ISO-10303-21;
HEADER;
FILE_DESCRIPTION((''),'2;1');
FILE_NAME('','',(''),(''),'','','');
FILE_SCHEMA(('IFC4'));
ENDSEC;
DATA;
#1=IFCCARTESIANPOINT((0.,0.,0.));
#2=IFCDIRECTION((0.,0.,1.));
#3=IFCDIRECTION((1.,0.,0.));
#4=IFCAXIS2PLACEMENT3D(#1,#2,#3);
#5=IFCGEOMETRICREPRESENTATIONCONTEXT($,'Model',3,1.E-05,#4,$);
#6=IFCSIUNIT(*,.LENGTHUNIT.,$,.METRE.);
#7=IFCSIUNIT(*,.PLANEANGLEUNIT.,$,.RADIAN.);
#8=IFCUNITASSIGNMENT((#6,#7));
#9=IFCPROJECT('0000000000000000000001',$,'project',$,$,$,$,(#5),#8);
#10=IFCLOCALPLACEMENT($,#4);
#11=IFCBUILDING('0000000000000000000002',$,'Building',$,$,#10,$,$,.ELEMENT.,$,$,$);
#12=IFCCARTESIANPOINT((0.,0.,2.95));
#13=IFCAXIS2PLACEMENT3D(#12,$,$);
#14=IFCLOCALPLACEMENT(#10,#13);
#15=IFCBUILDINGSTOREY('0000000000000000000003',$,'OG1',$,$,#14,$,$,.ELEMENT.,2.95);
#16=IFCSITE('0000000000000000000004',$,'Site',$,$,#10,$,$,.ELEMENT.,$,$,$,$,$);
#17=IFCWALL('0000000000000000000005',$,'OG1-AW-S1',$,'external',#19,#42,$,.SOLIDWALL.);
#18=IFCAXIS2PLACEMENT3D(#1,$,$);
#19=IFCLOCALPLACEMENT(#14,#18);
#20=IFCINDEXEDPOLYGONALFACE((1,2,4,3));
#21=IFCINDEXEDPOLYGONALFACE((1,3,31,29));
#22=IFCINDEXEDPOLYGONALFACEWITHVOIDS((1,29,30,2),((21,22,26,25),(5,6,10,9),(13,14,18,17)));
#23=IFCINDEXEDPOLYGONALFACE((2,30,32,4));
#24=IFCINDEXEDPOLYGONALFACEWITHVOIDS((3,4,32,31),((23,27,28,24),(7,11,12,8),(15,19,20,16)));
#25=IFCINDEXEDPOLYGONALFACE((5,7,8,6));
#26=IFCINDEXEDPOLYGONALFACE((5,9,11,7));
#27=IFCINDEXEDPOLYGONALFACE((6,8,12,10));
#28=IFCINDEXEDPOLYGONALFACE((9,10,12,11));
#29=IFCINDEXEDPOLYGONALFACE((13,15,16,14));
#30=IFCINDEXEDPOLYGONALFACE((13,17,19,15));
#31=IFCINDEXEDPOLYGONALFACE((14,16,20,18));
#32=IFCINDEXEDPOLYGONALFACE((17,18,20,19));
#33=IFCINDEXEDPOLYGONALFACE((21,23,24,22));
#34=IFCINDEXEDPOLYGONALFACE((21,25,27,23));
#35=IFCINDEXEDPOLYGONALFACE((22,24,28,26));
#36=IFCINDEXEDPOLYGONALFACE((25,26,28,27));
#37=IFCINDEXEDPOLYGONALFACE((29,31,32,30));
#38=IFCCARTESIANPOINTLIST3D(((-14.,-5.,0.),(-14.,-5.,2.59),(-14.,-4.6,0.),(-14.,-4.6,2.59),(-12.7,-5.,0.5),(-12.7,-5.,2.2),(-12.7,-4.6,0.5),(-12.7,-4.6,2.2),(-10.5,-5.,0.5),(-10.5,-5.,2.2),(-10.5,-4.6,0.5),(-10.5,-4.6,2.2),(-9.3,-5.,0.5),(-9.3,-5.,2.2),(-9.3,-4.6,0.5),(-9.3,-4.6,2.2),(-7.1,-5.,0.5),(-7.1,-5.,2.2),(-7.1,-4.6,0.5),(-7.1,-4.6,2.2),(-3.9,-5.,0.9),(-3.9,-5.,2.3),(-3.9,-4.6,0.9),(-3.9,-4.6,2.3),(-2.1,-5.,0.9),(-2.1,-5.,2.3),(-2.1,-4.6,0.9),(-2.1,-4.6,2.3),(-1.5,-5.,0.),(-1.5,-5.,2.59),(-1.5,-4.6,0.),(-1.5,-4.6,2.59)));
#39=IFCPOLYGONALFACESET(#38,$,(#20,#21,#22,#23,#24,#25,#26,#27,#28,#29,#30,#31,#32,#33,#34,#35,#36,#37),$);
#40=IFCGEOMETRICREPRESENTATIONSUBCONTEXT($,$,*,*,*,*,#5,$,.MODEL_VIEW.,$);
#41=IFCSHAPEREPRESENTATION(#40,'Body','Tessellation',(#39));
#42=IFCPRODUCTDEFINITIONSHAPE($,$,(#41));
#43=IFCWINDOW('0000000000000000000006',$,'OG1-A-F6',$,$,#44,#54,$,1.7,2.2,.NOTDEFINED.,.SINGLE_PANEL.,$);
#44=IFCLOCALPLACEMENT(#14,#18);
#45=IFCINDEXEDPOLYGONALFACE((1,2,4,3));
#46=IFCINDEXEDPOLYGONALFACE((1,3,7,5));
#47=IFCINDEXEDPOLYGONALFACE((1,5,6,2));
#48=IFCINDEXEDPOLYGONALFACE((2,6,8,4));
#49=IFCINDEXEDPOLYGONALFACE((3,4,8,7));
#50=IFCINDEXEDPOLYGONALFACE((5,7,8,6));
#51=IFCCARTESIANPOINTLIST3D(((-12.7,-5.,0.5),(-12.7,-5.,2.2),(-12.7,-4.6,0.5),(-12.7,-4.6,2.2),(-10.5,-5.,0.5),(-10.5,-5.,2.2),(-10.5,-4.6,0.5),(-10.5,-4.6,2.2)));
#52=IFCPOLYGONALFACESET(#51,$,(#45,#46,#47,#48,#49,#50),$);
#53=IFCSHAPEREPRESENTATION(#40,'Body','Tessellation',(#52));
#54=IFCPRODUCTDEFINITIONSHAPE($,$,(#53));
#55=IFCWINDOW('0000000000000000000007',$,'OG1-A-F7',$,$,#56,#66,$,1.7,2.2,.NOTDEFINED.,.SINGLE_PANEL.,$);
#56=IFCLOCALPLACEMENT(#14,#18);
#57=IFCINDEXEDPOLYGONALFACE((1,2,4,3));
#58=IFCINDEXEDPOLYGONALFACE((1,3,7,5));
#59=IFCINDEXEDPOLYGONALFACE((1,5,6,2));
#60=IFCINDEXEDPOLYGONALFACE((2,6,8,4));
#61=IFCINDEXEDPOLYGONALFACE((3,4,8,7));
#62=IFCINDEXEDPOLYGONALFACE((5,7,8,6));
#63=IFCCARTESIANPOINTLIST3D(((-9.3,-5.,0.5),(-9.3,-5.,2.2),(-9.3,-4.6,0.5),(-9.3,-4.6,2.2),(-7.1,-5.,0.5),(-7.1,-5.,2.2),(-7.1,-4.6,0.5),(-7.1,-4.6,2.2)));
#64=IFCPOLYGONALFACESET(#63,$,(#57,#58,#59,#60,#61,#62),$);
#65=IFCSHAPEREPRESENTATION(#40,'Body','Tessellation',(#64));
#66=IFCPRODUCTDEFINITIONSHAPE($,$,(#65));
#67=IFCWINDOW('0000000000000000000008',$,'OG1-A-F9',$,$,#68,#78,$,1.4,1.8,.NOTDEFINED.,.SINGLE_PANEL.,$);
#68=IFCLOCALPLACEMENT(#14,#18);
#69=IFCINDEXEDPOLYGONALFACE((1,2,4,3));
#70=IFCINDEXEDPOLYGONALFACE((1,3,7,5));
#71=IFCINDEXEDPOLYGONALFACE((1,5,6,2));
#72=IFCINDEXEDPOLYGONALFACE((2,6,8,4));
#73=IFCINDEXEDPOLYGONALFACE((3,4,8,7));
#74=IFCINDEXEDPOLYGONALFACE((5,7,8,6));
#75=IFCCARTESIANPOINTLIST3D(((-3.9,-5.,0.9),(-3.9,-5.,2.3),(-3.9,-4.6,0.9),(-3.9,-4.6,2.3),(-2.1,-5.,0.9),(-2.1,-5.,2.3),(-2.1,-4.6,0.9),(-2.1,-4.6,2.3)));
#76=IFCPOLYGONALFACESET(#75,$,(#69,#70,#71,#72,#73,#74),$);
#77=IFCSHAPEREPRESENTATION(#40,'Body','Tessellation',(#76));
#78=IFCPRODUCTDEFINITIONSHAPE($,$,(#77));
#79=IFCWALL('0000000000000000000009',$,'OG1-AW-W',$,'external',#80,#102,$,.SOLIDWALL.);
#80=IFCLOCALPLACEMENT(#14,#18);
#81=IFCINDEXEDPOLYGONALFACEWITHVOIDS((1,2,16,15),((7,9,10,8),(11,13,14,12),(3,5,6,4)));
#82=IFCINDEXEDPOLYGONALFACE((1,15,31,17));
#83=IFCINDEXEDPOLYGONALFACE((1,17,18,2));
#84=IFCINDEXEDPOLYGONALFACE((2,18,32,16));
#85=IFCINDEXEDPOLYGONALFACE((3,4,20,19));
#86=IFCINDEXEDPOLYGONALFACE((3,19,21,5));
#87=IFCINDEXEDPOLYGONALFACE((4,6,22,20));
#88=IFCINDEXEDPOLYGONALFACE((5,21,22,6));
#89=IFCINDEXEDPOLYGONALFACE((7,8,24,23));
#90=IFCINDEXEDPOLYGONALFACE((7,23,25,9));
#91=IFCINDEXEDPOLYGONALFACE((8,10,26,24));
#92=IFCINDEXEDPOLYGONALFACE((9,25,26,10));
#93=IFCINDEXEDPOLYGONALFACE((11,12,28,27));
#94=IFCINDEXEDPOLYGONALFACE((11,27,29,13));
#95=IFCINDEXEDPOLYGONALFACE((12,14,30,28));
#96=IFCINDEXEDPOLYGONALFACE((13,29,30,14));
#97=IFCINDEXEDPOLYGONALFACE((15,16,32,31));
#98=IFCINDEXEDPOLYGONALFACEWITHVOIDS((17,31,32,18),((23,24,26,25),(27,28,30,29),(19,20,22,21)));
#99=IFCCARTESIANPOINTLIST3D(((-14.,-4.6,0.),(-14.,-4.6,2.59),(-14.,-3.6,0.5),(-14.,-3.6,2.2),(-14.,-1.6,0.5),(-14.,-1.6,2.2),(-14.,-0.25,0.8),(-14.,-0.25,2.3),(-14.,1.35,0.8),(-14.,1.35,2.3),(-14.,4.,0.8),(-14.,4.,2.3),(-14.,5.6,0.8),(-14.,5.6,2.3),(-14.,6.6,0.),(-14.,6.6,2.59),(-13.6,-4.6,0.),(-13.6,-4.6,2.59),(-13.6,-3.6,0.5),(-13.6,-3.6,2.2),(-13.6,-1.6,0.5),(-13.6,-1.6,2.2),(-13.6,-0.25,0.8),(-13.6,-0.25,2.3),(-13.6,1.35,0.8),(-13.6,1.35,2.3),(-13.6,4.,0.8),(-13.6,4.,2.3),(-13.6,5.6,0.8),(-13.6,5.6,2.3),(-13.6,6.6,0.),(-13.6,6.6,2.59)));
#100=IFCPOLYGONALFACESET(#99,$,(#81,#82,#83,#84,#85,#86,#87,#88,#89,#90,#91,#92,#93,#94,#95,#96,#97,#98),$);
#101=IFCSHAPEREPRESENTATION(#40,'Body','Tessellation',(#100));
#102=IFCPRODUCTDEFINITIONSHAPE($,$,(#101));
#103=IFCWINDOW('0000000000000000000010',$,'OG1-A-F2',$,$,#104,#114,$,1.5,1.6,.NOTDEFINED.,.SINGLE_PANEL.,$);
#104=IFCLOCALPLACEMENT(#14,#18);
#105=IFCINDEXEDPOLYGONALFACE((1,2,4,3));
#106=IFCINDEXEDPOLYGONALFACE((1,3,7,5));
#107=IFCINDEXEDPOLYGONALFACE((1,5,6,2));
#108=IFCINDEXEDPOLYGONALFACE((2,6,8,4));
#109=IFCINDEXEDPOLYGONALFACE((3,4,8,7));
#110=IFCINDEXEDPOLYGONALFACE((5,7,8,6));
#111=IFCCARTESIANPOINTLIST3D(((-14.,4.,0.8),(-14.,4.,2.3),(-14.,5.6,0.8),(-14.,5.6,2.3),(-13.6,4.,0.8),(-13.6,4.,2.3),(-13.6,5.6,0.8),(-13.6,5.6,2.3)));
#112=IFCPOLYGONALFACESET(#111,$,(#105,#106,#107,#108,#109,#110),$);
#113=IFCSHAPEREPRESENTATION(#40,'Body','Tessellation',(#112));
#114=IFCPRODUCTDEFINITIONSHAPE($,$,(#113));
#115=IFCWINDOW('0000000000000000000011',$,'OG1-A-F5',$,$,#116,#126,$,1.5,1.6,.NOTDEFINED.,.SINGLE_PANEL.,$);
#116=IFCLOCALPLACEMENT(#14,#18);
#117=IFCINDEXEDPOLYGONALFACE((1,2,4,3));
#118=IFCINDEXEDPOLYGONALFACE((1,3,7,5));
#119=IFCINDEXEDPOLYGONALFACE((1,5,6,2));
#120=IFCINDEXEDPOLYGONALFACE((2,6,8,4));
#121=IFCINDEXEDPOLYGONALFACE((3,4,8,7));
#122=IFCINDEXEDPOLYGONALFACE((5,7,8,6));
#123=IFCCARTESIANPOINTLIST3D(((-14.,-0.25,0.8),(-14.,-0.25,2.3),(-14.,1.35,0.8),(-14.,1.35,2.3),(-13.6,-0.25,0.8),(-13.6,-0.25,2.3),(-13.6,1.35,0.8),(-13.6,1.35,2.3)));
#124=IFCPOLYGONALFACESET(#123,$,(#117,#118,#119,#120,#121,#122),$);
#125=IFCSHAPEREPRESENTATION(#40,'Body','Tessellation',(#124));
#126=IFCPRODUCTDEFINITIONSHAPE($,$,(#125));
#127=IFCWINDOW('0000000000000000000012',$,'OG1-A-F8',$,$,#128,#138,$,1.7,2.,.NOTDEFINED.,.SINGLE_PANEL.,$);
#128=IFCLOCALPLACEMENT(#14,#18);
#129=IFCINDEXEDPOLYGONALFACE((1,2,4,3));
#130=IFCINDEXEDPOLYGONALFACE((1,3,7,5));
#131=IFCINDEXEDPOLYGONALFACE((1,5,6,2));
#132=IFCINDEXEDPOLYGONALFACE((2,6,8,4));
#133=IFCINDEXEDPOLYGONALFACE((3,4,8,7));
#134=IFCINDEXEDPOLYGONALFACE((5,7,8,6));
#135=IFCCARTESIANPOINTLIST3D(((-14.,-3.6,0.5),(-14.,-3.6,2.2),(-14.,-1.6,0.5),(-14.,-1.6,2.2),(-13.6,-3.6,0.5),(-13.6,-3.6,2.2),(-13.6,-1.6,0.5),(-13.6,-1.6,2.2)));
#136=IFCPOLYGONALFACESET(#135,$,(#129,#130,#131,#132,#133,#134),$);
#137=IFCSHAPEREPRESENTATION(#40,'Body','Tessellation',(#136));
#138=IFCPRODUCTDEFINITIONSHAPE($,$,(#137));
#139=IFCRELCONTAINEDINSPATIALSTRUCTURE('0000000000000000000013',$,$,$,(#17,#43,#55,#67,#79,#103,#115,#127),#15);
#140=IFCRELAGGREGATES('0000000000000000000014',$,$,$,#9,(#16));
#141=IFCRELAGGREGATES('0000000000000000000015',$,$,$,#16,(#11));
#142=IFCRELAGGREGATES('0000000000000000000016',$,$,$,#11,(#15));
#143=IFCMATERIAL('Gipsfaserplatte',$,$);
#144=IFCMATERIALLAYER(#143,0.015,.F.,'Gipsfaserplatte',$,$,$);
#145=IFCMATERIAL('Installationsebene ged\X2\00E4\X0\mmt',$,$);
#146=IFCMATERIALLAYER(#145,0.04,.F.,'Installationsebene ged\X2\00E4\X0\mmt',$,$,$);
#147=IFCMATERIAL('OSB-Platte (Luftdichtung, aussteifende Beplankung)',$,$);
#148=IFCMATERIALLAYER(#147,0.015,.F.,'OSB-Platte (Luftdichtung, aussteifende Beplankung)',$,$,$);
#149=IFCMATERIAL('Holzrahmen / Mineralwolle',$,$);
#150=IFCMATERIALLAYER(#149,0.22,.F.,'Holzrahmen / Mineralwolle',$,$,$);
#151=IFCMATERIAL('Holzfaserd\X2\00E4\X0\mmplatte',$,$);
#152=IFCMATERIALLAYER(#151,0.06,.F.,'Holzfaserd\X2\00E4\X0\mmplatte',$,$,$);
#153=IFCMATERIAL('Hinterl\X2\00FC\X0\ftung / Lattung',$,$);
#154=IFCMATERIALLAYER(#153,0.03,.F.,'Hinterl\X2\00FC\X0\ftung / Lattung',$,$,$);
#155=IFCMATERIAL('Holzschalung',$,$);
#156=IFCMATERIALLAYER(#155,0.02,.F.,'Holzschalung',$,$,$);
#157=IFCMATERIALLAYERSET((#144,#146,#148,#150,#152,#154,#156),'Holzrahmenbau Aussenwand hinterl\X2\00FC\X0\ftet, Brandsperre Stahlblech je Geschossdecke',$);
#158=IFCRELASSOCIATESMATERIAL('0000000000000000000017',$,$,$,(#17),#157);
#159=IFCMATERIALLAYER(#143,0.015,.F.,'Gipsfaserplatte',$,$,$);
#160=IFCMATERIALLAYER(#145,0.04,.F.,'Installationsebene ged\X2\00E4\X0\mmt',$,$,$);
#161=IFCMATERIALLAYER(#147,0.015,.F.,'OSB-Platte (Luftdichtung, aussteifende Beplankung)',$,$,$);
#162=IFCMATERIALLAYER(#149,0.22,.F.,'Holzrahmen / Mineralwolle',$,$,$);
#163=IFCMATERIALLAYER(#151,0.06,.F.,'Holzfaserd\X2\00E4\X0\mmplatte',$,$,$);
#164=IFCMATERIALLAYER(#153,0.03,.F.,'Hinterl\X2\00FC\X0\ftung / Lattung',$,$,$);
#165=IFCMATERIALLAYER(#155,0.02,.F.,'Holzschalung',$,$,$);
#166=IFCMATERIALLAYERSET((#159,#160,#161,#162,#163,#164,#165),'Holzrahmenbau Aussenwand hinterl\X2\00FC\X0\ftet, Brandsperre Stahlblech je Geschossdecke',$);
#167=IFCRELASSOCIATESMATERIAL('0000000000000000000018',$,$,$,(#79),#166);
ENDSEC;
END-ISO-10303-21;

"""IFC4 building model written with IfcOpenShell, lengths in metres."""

from ifc_helpers import new_model, si_unit, frame, frame_2d, origin, origin_with_axes, place, context, subcontext, project, spatial, rectangle, extrude, material, layer, layer_set, element, fill, save


model = new_model("IFC4")

# Units and contexts
model_context = context("Model", 3, precision=1e-05, world=origin_with_axes())
sub_context = subcontext(model_context, None, None, "MODEL_VIEW")
ifc_project = project(units=[si_unit("LENGTHUNIT", "METRE"), si_unit("PLANEANGLEUNIT", "RADIAN")], contexts=[model_context])

# Site, building, storey
placement = place(None, origin_with_axes())
site = spatial("IfcSite", under=ifc_project, at=placement, Name="Site", CompositionType="ELEMENT")
building = spatial("IfcBuilding", under=site, at=placement, Name="Building", CompositionType="ELEMENT")
storey_placement = place(placement, frame((0.0, 0.0, 2.95)))
storey = spatial("IfcBuildingStorey", under=building, at=storey_placement, Name="OG1", CompositionType="ELEMENT", Elevation=2.95)

# Walls, openings, windows
ifc_material_1 = material(Name="Gipsfaserplatte")
ifc_layer_1 = layer(ifc_material_1, 0.015, ventilated=False, Name="Gipsfaserplatte")
ifc_material_2 = material(Name="Installationsebene gedämmt")
ifc_layer_2 = layer(ifc_material_2, 0.04, ventilated=False, Name="Installationsebene gedämmt")
ifc_material_3 = material(Name="OSB-Platte (Luftdichtung, aussteifende Beplankung)")
ifc_layer_3 = layer(ifc_material_3, 0.015, ventilated=False, Name="OSB-Platte (Luftdichtung, aussteifende Beplankung)")
ifc_material_4 = material(Name="Holzrahmen / Mineralwolle")
ifc_layer_4 = layer(ifc_material_4, 0.22, ventilated=False, Name="Holzrahmen / Mineralwolle")
ifc_material_5 = material(Name="Holzfaserdämmplatte")
ifc_layer_5 = layer(ifc_material_5, 0.06, ventilated=False, Name="Holzfaserdämmplatte")
ifc_material_6 = material(Name="Hinterlüftung / Lattung")
ifc_layer_6 = layer(ifc_material_6, 0.03, ventilated=False, Name="Hinterlüftung / Lattung")
ifc_material_7 = material(Name="Holzschalung")
ifc_layer_7 = layer(ifc_material_7, 0.02, ventilated=False, Name="Holzschalung")
ifc_layer_set_1 = layer_set([ifc_layer_1, ifc_layer_2, ifc_layer_3, ifc_layer_4, ifc_layer_5, ifc_layer_6, ifc_layer_7], Name="Holzrahmenbau Aussenwand hinterlüftet, Brandsperre Stahlblech je Geschossdecke")
wall_1_placement = place(storey_placement, frame((-14.0, -4.8, 0.0), z_axis=(0.0, 0.0, 1.0), x_axis=(1.0, 0.0, 0.0)))
wall_1 = element("IfcWall", 1, at=wall_1_placement, inside=storey, material=ifc_layer_set_1, Name="OG1-AW-S1", ObjectType="external", PredefinedType="SOLIDWALL", context=sub_context, shape_type="SweptSolid", body=[
    extrude(rectangle(XDim=12.5, YDim=0.4, at=frame_2d((6.25, 0.0))), origin(), (0.0, 0.0, 1.0), 2.59),
])
opening_1_placement = place(wall_1_placement, frame((2.4, 0.25, 0.5), z_axis=(0.0, -1.0, 0.0), x_axis=(1.0, 0.0, 0.0)))
opening_1 = element("IfcOpeningElement", 2, at=opening_1_placement, cuts=wall_1, PredefinedType="OPENING", context=sub_context, shape_type="SweptSolid", body=[
    extrude(rectangle(XDim=2.2, YDim=1.7, at=frame_2d((0.0, 0.85))), origin(), (0.0, 0.0, 1.0), 0.5),
])
opening_2_placement = place(wall_1_placement, frame((5.8, 0.25, 0.5), z_axis=(0.0, -1.0, 0.0), x_axis=(1.0, 0.0, 0.0)))
opening_2 = element("IfcOpeningElement", 3, at=opening_2_placement, cuts=wall_1, PredefinedType="OPENING", context=sub_context, shape_type="SweptSolid", body=[
    extrude(rectangle(XDim=2.2, YDim=1.7, at=frame_2d((0.0, 0.85))), origin(), (0.0, 0.0, 1.0), 0.5),
])
opening_3_placement = place(wall_1_placement, frame((11.0, 0.25, 0.9), z_axis=(0.0, -1.0, 0.0), x_axis=(1.0, 0.0, 0.0)))
opening_3 = element("IfcOpeningElement", 4, at=opening_3_placement, cuts=wall_1, PredefinedType="OPENING", context=sub_context, shape_type="SweptSolid", body=[
    extrude(rectangle(XDim=1.8, YDim=1.4, at=frame_2d((0.0, 0.7))), origin(), (0.0, 0.0, 1.0), 0.5),
])
window_1_placement = place(wall_1_placement, frame((2.4, 0.2, 0.5), z_axis=(0.0, -1.0, 0.0), x_axis=(1.0, 0.0, 0.0)))
window_1 = element("IfcWindow", 5, at=window_1_placement, inside=storey, Name="OG1-A-F6", OverallHeight=1.7, OverallWidth=2.2, PartitioningType="SINGLE_PANEL", PredefinedType="NOTDEFINED", context=sub_context, shape_type="SweptSolid", body=[
    extrude(rectangle(XDim=2.2, YDim=1.7, at=frame_2d((0.0, 0.85))), origin(), (0.0, 0.0, 1.0), 0.4),
])
fill(opening_1, window_1)
window_2_placement = place(wall_1_placement, frame((5.8, 0.2, 0.5), z_axis=(0.0, -1.0, 0.0), x_axis=(1.0, 0.0, 0.0)))
window_2 = element("IfcWindow", 6, at=window_2_placement, inside=storey, Name="OG1-A-F7", OverallHeight=1.7, OverallWidth=2.2, PartitioningType="SINGLE_PANEL", PredefinedType="NOTDEFINED", context=sub_context, shape_type="SweptSolid", body=[
    extrude(rectangle(XDim=2.2, YDim=1.7, at=frame_2d((0.0, 0.85))), origin(), (0.0, 0.0, 1.0), 0.4),
])
fill(opening_2, window_2)
window_3_placement = place(wall_1_placement, frame((11.0, 0.2, 0.9), z_axis=(0.0, -1.0, 0.0), x_axis=(1.0, 0.0, 0.0)))
window_3 = element("IfcWindow", 7, at=window_3_placement, inside=storey, Name="OG1-A-F9", OverallHeight=1.4, OverallWidth=1.8, PartitioningType="SINGLE_PANEL", PredefinedType="NOTDEFINED", context=sub_context, shape_type="SweptSolid", body=[
    extrude(rectangle(XDim=1.8, YDim=1.4, at=frame_2d((0.0, 0.7))), origin(), (0.0, 0.0, 1.0), 0.4),
])
fill(opening_3, window_3)
ifc_layer_8 = layer(ifc_material_1, 0.015, ventilated=False, Name="Gipsfaserplatte")
ifc_layer_9 = layer(ifc_material_2, 0.04, ventilated=False, Name="Installationsebene gedämmt")
ifc_layer_10 = layer(ifc_material_3, 0.015, ventilated=False, Name="OSB-Platte (Luftdichtung, aussteifende Beplankung)")
ifc_layer_11 = layer(ifc_material_4, 0.22, ventilated=False, Name="Holzrahmen / Mineralwolle")
ifc_layer_12 = layer(ifc_material_5, 0.06, ventilated=False, Name="Holzfaserdämmplatte")
ifc_layer_13 = layer(ifc_material_6, 0.03, ventilated=False, Name="Hinterlüftung / Lattung")
ifc_layer_14 = layer(ifc_material_7, 0.02, ventilated=False, Name="Holzschalung")
ifc_layer_set_2 = layer_set([ifc_layer_8, ifc_layer_9, ifc_layer_10, ifc_layer_11, ifc_layer_12, ifc_layer_13, ifc_layer_14], Name="Holzrahmenbau Aussenwand hinterlüftet, Brandsperre Stahlblech je Geschossdecke")
wall_2_placement = place(storey_placement, frame((-13.8, -4.6, 0.0), z_axis=(0.0, 0.0, 1.0), x_axis=(0.0, 1.0, 0.0)))
wall_2 = element("IfcWall", 8, at=wall_2_placement, inside=storey, material=ifc_layer_set_2, Name="OG1-AW-W", ObjectType="external", PredefinedType="SOLIDWALL", context=sub_context, shape_type="SweptSolid", body=[
    extrude(rectangle(XDim=11.2, YDim=0.4, at=frame_2d((5.6, 0.0))), origin(), (0.0, 0.0, 1.0), 2.59),
])
opening_4_placement = place(wall_2_placement, frame((9.4, 0.25, 0.8), z_axis=(0.0, -1.0, 0.0), x_axis=(1.0, 0.0, 0.0)))
opening_4 = element("IfcOpeningElement", 9, at=opening_4_placement, cuts=wall_2, PredefinedType="OPENING", context=sub_context, shape_type="SweptSolid", body=[
    extrude(rectangle(XDim=1.6, YDim=1.5, at=frame_2d((0.0, 0.75))), origin(), (0.0, 0.0, 1.0), 0.5),
])
opening_5_placement = place(wall_2_placement, frame((5.15, 0.25, 0.8), z_axis=(0.0, -1.0, 0.0), x_axis=(1.0, 0.0, 0.0)))
opening_5 = element("IfcOpeningElement", 10, at=opening_5_placement, cuts=wall_2, PredefinedType="OPENING", context=sub_context, shape_type="SweptSolid", body=[
    extrude(rectangle(XDim=1.6, YDim=1.5, at=frame_2d((0.0, 0.75))), origin(), (0.0, 0.0, 1.0), 0.5),
])
opening_6_placement = place(wall_2_placement, frame((2.0, 0.25, 0.5), z_axis=(0.0, -1.0, 0.0), x_axis=(1.0, 0.0, 0.0)))
opening_6 = element("IfcOpeningElement", 11, at=opening_6_placement, cuts=wall_2, PredefinedType="OPENING", context=sub_context, shape_type="SweptSolid", body=[
    extrude(rectangle(XDim=2.0, YDim=1.7, at=frame_2d((0.0, 0.85))), origin(), (0.0, 0.0, 1.0), 0.5),
])
window_4_placement = place(wall_2_placement, frame((9.4, 0.2, 0.8), z_axis=(0.0, -1.0, 0.0), x_axis=(1.0, 0.0, 0.0)))
window_4 = element("IfcWindow", 12, at=window_4_placement, inside=storey, Name="OG1-A-F2", OverallHeight=1.5, OverallWidth=1.6, PartitioningType="SINGLE_PANEL", PredefinedType="NOTDEFINED", context=sub_context, shape_type="SweptSolid", body=[
    extrude(rectangle(XDim=1.6, YDim=1.5, at=frame_2d((0.0, 0.75))), origin(), (0.0, 0.0, 1.0), 0.4),
])
fill(opening_4, window_4)
window_5_placement = place(wall_2_placement, frame((5.15, 0.2, 0.8), z_axis=(0.0, -1.0, 0.0), x_axis=(1.0, 0.0, 0.0)))
window_5 = element("IfcWindow", 13, at=window_5_placement, inside=storey, Name="OG1-A-F5", OverallHeight=1.5, OverallWidth=1.6, PartitioningType="SINGLE_PANEL", PredefinedType="NOTDEFINED", context=sub_context, shape_type="SweptSolid", body=[
    extrude(rectangle(XDim=1.6, YDim=1.5, at=frame_2d((0.0, 0.75))), origin(), (0.0, 0.0, 1.0), 0.4),
])
fill(opening_5, window_5)
window_6_placement = place(wall_2_placement, frame((2.0, 0.2, 0.5), z_axis=(0.0, -1.0, 0.0), x_axis=(1.0, 0.0, 0.0)))
window_6 = element("IfcWindow", 14, at=window_6_placement, inside=storey, Name="OG1-A-F8", OverallHeight=1.7, OverallWidth=2.0, PartitioningType="SINGLE_PANEL", PredefinedType="NOTDEFINED", context=sub_context, shape_type="SweptSolid", body=[
    extrude(rectangle(XDim=2.0, YDim=1.7, at=frame_2d((0.0, 0.85))), origin(), (0.0, 0.0, 1.0), 0.4),
])
fill(opening_6, window_6)

save(model, "model.ifc")
